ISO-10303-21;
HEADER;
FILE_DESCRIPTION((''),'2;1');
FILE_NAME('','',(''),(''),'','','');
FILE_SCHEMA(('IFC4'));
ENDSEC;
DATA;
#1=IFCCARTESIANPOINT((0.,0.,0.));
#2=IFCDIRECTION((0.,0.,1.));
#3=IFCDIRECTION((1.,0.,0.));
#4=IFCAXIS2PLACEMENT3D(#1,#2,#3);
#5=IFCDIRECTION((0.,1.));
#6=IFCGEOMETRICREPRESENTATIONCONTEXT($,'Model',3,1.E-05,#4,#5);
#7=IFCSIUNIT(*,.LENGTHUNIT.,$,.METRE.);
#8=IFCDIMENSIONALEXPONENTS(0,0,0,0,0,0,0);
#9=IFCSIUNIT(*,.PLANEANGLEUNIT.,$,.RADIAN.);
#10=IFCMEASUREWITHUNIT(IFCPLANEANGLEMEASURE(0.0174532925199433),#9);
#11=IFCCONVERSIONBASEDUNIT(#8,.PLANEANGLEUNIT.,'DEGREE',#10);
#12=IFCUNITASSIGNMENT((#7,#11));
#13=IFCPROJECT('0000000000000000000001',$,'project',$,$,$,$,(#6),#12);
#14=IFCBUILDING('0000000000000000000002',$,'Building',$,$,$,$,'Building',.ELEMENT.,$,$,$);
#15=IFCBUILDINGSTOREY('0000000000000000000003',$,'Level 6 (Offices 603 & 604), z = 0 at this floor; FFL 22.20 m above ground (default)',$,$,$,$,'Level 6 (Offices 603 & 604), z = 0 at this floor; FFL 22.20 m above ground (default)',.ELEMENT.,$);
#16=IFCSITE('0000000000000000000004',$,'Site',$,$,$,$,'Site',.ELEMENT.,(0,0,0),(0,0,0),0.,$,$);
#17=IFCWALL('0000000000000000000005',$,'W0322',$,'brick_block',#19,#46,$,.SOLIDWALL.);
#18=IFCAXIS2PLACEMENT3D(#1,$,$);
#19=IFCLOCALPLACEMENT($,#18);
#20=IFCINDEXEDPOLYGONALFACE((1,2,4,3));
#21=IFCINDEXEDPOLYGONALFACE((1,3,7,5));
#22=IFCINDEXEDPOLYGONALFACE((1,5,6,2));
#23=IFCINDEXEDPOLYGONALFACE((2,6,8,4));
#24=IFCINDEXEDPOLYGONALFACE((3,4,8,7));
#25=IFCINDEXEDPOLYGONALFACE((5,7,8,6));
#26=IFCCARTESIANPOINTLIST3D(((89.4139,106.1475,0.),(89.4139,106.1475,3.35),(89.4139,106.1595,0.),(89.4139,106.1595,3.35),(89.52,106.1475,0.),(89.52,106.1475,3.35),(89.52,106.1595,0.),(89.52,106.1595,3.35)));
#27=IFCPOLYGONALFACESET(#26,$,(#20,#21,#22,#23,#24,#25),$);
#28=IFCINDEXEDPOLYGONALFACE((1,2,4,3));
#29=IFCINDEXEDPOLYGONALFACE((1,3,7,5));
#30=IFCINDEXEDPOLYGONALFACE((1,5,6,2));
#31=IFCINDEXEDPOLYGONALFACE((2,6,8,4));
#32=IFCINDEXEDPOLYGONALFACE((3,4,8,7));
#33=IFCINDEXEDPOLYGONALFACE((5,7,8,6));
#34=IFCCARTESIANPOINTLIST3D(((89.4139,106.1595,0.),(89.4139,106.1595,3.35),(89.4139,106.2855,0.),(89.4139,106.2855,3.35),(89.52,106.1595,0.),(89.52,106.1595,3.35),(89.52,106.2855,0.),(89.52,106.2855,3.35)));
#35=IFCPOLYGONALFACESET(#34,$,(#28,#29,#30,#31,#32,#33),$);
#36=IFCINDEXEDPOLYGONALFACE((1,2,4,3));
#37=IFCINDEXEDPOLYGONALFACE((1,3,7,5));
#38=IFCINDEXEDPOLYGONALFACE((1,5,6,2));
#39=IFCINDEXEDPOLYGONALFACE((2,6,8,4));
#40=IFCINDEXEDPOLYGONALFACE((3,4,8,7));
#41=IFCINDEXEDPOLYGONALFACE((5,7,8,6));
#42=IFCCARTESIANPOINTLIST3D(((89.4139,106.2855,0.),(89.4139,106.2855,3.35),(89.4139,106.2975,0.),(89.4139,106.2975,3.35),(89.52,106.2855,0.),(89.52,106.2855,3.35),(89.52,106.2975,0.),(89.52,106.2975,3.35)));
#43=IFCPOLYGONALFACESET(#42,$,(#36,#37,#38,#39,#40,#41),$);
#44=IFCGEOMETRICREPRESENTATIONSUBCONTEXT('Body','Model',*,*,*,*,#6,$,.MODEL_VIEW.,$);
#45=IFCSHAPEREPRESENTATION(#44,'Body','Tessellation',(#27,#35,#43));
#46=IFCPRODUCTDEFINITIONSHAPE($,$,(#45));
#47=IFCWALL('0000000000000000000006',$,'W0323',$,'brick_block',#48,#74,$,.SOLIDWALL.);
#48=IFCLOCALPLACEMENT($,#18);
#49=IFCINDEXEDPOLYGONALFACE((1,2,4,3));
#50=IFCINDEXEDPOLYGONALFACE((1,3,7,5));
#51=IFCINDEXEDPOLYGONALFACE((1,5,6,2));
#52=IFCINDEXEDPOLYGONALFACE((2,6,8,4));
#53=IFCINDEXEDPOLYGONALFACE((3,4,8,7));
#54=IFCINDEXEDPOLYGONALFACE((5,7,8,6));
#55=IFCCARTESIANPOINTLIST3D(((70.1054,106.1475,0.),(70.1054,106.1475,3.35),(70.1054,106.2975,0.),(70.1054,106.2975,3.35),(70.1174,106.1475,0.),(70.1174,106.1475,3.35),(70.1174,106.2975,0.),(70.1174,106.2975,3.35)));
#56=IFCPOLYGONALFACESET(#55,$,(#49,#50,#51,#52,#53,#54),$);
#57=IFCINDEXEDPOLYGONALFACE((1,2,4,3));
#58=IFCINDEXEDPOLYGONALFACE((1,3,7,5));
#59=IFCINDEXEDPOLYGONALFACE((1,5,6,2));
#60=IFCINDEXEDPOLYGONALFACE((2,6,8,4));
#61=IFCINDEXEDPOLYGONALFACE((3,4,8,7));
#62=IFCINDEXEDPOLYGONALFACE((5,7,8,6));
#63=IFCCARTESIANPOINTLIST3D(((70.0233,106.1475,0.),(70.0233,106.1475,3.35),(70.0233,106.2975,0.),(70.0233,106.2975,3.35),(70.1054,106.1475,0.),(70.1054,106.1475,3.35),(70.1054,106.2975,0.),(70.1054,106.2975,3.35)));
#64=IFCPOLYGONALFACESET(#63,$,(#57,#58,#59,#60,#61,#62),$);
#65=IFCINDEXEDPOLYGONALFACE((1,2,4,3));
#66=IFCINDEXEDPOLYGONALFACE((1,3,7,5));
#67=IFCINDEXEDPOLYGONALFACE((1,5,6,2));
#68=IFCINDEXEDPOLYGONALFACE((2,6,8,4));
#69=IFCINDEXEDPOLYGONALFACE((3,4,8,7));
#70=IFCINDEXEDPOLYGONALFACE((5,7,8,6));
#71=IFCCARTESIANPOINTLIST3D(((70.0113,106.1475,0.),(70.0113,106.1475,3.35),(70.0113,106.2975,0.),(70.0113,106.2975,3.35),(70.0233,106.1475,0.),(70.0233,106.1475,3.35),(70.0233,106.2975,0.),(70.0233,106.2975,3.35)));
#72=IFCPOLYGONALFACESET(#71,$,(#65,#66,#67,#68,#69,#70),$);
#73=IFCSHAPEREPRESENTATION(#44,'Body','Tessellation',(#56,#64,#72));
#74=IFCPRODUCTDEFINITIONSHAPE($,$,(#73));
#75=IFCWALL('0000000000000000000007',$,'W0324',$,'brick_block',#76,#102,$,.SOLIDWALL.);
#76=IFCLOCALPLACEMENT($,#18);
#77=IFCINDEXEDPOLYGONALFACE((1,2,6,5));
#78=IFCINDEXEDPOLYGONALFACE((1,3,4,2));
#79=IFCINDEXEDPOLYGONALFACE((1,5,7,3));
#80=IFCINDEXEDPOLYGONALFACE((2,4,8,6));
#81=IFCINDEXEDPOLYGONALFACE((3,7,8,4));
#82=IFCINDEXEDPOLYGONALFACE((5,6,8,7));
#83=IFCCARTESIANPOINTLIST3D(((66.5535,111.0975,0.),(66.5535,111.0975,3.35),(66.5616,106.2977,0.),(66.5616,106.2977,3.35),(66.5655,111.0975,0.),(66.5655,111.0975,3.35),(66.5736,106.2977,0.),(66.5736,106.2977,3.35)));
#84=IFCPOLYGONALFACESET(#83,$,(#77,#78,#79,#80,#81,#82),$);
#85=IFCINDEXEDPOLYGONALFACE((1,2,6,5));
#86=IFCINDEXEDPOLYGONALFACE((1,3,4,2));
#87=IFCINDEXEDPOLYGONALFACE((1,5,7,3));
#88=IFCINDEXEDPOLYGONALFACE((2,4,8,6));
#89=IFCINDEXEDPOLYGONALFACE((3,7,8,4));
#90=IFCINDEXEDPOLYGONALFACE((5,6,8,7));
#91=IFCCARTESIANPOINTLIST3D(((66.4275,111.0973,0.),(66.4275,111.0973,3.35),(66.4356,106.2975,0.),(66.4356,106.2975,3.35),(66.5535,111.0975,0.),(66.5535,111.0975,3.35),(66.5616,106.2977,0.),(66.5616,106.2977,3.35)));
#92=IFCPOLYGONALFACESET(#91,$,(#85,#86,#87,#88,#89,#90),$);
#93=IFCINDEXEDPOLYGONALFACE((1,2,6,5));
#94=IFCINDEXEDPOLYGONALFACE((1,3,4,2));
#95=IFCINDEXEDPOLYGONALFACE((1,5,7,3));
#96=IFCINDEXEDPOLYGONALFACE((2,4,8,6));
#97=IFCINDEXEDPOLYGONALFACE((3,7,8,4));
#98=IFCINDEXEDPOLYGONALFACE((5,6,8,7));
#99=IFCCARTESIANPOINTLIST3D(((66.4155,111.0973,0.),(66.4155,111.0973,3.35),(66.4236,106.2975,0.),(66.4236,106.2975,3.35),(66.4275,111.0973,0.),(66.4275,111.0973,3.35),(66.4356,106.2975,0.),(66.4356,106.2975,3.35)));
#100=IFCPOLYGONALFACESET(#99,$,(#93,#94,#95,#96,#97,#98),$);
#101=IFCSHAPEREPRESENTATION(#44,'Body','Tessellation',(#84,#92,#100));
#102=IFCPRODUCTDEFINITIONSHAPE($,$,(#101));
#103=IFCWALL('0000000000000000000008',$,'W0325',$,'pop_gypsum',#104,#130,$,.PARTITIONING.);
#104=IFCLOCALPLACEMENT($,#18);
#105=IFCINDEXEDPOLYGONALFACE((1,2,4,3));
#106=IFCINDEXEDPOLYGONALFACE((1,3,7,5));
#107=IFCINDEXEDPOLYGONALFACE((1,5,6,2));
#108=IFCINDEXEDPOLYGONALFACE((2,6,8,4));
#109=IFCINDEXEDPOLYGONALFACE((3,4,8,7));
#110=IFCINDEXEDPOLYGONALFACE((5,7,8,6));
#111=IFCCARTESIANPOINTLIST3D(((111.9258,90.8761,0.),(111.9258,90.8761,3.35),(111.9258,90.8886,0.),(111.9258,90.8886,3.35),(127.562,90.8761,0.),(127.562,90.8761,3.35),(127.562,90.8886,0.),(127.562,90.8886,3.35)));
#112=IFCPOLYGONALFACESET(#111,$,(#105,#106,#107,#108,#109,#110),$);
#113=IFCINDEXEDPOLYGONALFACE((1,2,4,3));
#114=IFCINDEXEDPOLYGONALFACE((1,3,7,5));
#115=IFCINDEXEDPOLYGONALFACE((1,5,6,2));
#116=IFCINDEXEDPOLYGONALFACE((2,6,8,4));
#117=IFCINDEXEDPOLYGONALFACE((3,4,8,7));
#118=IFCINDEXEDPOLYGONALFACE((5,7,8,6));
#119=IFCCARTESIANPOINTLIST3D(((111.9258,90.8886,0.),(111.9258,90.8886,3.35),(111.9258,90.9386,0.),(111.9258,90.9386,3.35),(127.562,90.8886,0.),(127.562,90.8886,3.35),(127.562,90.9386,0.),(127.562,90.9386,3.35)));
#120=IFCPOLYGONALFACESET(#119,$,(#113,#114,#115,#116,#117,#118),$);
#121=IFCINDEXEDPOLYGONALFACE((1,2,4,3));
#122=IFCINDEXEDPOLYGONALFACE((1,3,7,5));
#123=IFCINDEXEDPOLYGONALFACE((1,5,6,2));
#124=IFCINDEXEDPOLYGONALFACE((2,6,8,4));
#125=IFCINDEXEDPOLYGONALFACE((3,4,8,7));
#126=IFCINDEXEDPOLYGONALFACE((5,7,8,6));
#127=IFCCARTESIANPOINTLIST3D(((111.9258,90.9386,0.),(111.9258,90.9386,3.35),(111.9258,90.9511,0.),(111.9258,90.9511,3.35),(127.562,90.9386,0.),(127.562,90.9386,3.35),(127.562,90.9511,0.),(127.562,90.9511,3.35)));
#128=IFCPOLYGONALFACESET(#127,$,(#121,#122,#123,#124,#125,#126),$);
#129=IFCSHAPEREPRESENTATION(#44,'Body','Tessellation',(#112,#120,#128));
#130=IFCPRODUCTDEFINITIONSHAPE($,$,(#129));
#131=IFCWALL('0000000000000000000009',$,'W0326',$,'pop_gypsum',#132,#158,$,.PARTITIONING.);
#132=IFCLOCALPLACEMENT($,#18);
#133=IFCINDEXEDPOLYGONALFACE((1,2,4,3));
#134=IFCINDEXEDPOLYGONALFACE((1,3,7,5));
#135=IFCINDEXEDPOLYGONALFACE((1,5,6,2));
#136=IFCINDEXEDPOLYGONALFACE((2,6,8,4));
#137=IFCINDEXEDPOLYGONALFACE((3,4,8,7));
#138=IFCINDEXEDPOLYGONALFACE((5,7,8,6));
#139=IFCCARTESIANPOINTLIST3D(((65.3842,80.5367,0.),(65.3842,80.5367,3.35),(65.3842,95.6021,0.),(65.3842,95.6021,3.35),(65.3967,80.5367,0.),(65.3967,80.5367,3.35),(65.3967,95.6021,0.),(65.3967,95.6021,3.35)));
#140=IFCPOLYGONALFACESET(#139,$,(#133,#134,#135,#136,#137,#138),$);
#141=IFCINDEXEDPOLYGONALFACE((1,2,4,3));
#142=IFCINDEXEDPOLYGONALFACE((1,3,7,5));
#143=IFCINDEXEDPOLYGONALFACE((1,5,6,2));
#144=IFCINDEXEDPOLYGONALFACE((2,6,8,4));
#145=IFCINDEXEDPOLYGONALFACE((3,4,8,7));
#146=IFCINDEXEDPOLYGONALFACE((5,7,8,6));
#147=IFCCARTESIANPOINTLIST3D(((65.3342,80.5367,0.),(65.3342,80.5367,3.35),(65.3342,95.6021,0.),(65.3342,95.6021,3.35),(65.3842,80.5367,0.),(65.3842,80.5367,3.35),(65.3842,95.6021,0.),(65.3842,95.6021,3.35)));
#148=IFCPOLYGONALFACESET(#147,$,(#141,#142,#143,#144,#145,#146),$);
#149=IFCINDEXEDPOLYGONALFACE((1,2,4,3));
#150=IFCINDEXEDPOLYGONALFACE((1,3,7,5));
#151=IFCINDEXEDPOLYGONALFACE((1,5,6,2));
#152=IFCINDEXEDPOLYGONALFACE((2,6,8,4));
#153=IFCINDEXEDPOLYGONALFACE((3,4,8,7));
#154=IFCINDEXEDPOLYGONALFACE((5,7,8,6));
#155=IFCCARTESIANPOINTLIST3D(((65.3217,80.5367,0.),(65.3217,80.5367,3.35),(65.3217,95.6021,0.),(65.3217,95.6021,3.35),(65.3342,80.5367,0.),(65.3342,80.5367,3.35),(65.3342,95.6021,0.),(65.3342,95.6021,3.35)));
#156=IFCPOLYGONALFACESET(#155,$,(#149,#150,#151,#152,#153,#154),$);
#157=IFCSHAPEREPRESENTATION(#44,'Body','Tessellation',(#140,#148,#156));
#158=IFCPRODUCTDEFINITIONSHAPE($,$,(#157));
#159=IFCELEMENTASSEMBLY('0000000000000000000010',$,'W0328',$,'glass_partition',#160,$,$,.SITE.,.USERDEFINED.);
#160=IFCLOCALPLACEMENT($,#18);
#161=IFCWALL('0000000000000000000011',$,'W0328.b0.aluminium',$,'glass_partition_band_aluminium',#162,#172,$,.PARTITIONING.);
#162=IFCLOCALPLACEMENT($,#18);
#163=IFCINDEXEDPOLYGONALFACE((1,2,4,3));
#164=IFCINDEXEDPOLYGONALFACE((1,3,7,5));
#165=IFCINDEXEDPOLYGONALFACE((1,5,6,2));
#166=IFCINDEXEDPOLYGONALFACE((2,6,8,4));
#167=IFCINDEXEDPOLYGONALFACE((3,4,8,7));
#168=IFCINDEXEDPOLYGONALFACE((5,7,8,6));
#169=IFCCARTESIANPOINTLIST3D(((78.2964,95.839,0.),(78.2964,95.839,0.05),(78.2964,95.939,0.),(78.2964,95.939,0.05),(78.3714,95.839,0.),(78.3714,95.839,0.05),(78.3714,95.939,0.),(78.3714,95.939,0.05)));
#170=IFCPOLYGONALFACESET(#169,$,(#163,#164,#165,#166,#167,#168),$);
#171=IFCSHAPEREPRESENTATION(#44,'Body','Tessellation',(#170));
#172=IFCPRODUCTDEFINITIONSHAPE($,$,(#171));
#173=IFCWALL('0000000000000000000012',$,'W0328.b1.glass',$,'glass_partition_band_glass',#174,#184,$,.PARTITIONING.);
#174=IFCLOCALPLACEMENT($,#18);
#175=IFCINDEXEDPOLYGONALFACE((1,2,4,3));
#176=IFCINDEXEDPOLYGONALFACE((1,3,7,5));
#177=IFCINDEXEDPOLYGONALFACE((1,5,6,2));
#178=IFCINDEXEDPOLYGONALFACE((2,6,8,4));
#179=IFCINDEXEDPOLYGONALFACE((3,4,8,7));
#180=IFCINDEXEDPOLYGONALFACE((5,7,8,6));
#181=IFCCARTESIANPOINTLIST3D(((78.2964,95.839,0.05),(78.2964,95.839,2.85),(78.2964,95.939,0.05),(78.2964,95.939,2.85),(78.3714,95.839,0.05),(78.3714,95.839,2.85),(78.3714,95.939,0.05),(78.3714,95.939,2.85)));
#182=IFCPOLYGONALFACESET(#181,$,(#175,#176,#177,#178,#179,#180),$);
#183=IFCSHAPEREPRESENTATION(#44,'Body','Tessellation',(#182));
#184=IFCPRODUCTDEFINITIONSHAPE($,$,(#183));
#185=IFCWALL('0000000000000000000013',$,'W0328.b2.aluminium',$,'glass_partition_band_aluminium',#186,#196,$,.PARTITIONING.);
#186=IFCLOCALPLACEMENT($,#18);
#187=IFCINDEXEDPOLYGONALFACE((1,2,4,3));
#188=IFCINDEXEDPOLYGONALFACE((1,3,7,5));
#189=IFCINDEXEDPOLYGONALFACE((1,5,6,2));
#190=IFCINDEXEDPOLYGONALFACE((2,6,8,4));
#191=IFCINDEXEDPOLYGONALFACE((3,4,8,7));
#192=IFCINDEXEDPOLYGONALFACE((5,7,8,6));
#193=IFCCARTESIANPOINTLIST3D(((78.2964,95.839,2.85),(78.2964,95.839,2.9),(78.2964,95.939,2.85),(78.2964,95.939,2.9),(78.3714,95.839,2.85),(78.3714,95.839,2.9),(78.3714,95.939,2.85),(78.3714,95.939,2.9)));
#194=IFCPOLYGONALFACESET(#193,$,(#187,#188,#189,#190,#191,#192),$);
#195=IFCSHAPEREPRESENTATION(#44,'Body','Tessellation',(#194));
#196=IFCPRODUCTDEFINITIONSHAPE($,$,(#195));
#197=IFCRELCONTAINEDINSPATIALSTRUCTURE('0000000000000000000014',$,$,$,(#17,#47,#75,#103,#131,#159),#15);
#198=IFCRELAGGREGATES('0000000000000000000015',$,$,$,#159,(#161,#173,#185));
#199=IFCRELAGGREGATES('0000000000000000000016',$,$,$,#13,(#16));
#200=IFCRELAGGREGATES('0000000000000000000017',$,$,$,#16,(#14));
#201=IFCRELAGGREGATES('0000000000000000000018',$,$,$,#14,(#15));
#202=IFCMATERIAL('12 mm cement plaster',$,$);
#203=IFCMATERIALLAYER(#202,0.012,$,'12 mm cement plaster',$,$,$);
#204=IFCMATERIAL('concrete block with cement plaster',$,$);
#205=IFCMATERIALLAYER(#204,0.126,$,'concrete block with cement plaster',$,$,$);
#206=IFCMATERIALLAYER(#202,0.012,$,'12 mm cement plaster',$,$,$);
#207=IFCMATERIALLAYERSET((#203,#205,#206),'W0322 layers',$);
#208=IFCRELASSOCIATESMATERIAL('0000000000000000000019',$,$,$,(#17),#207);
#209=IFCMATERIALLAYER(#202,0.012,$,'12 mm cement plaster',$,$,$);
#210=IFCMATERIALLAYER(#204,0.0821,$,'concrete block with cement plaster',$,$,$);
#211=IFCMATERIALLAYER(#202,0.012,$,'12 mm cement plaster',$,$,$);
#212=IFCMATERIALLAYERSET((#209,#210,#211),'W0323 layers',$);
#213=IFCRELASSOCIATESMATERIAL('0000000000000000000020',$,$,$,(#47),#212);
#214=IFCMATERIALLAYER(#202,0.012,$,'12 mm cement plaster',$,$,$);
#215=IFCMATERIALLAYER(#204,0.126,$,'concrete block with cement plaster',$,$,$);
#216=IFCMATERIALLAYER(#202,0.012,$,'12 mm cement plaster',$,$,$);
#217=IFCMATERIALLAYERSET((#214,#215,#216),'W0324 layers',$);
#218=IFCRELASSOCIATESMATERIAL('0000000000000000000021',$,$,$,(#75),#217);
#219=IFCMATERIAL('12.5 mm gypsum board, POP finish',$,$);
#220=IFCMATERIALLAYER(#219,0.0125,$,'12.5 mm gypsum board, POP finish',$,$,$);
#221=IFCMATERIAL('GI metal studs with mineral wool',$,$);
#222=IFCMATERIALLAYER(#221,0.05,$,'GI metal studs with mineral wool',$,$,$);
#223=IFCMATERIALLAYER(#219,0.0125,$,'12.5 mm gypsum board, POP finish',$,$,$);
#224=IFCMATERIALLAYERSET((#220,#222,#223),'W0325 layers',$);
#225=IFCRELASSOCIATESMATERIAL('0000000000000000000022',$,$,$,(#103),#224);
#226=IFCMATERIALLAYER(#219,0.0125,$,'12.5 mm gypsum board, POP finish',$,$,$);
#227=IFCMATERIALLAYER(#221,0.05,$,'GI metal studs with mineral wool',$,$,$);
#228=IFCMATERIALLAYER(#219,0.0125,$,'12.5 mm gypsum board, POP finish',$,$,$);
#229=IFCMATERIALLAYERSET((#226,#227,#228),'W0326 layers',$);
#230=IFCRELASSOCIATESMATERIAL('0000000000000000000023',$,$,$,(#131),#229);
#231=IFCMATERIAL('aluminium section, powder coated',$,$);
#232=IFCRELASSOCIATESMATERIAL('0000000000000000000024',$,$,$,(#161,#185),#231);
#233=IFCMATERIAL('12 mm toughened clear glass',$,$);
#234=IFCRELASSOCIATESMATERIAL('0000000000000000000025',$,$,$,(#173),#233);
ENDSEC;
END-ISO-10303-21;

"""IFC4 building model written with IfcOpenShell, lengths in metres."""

from ifc_helpers import new_model, entity, si_unit, converted_unit, direction, frame, frame_2d, origin_with_axes, origin_2d_with_axis, place, context, subcontext, project, spatial, rectangle, extrude, material, layer, layer_set, layer_usage, element, aggregate, save


model = new_model("IFC4")

# Units and contexts
model_context = context("Model", 3, precision=1e-05, world=origin_with_axes(), true_north=direction((0.0, 1.0)))
body_context = subcontext(model_context, "Body", "Model", "MODEL_VIEW")
ifc_project = project(units=[si_unit("LENGTHUNIT", "METRE"), converted_unit("PLANEANGLEUNIT", "DEGREE", entity("IfcPlaneAngleMeasure", 0.0174532925199433), si_unit("PLANEANGLEUNIT", "RADIAN"), dimensions=[0, 0, 0, 0, 0, 0, 0])], contexts=[model_context])

# Site, building, storey
site = spatial("IfcSite", under=ifc_project, Name="Site", LongName="Site", CompositionType="ELEMENT", RefLatitude=(0, 0, 0), RefLongitude=(0, 0, 0), RefElevation=0.0)
building = spatial("IfcBuilding", under=site, Name="Building", LongName="Building", CompositionType="ELEMENT")
storey = spatial("IfcBuildingStorey", under=building, Name="Level 6 (Offices 603 & 604), z = 0 at this floor; FFL 22.20 m above ground (default)", LongName="Level 6 (Offices 603 & 604), z = 0 at this floor; FFL 22.20 m above ground (default)", CompositionType="ELEMENT")

# Shared definitions
placement = place(None, origin_with_axes())

# Shared definitions
ifc_material_1 = material(Name="12 mm toughened clear glass")

# Walls
ifc_material_2 = material(Name="12 mm cement plaster")
ifc_material_3 = material(Name="concrete block with cement plaster")
ifc_layer_1 = layer(ifc_material_2, 0.012, Name="12 mm cement plaster")
ifc_layer_2 = layer(ifc_material_3, 0.126, Name="concrete block with cement plaster")
ifc_layer_3 = layer(ifc_material_2, 0.012, Name="12 mm cement plaster")
ifc_layer_set_1 = layer_set([ifc_layer_1, ifc_layer_2, ifc_layer_3], Name="W0322 layers")
ifc_layer_usage_1 = layer_usage(ifc_layer_set_1, "AXIS2", "POSITIVE", -0.075)
element("IfcWall", 1, at=placement, inside=storey, material=ifc_layer_usage_1, Name="W0322", ObjectType="brick_block", PredefinedType="SOLIDWALL", context=body_context, shape_type="SweptSolid", body=[
    extrude(rectangle(XDim=0.1061, YDim=0.012, at=origin_2d_with_axis()), frame((89.4669, 106.1535, 0.0), z_axis=(0.0, 0.0, 1.0), x_axis=(1.0, 0.0, 0.0)), (0.0, 0.0, 1.0), 3.35),
    extrude(rectangle(XDim=0.1061, YDim=0.126, at=frame_2d((0.0, 0.069), x_axis=(1.0, 0.0))), frame((89.4669, 106.1535, 0.0), z_axis=(0.0, 0.0, 1.0), x_axis=(1.0, 0.0, 0.0)), (0.0, 0.0, 1.0), 3.35),
    extrude(rectangle(XDim=0.1061, YDim=0.012, at=frame_2d((0.0, 0.138), x_axis=(1.0, 0.0))), frame((89.4669, 106.1535, 0.0), z_axis=(0.0, 0.0, 1.0), x_axis=(1.0, 0.0, 0.0)), (0.0, 0.0, 1.0), 3.35),
])
ifc_layer_4 = layer(ifc_material_2, 0.012, Name="12 mm cement plaster")
ifc_layer_5 = layer(ifc_material_3, 0.0821, Name="concrete block with cement plaster")
ifc_layer_6 = layer(ifc_material_2, 0.012, Name="12 mm cement plaster")
ifc_layer_set_2 = layer_set([ifc_layer_4, ifc_layer_5, ifc_layer_6], Name="W0323 layers")
ifc_layer_usage_2 = layer_usage(ifc_layer_set_2, "AXIS2", "POSITIVE", -0.053)
element("IfcWall", 2, at=placement, inside=storey, material=ifc_layer_usage_2, Name="W0323", ObjectType="brick_block", PredefinedType="SOLIDWALL", context=body_context, shape_type="SweptSolid", body=[
    extrude(rectangle(XDim=0.15, YDim=0.012, at=frame_2d((0.0, 0.0), x_axis=(0.0, 1.0))), frame((70.1115, 106.2225, 0.0), z_axis=(0.0, 0.0, 1.0), x_axis=(1.0, 0.0, 0.0)), (0.0, 0.0, 1.0), 3.35),
    extrude(rectangle(XDim=0.15, YDim=0.0821, at=frame_2d((-0.0471, 0.0), x_axis=(0.0, 1.0))), frame((70.1115, 106.2225, 0.0), z_axis=(0.0, 0.0, 1.0), x_axis=(1.0, 0.0, 0.0)), (0.0, 0.0, 1.0), 3.35),
    extrude(rectangle(XDim=0.15, YDim=0.012, at=frame_2d((-0.0941, 0.0), x_axis=(0.0, 1.0))), frame((70.1115, 106.2225, 0.0), z_axis=(0.0, 0.0, 1.0), x_axis=(1.0, 0.0, 0.0)), (0.0, 0.0, 1.0), 3.35),
])
ifc_layer_7 = layer(ifc_material_2, 0.012, Name="12 mm cement plaster")
ifc_layer_8 = layer(ifc_material_3, 0.126, Name="concrete block with cement plaster")
ifc_layer_9 = layer(ifc_material_2, 0.012, Name="12 mm cement plaster")
ifc_layer_set_3 = layer_set([ifc_layer_7, ifc_layer_8, ifc_layer_9], Name="W0324 layers")
ifc_layer_usage_3 = layer_usage(ifc_layer_set_3, "AXIS2", "POSITIVE", -0.075)
element("IfcWall", 3, at=placement, inside=storey, material=ifc_layer_usage_3, Name="W0324", ObjectType="brick_block", PredefinedType="SOLIDWALL", context=body_context, shape_type="SweptSolid", body=[
    extrude(rectangle(XDim=4.7998, YDim=0.012, at=frame_2d((0.0, 0.0), x_axis=(0.001688, -0.999999))), frame((66.5635, 108.6976, 0.0), z_axis=(0.0, 0.0, 1.0), x_axis=(1.0, 0.0, 0.0)), (0.0, 0.0, 1.0), 3.35),
    extrude(rectangle(XDim=4.7998, YDim=0.126, at=frame_2d((-0.069, -0.0001), x_axis=(0.001688, -0.999999))), frame((66.5635, 108.6976, 0.0), z_axis=(0.0, 0.0, 1.0), x_axis=(1.0, 0.0, 0.0)), (0.0, 0.0, 1.0), 3.35),
    extrude(rectangle(XDim=4.7998, YDim=0.012, at=frame_2d((-0.138, -0.0002), x_axis=(0.001688, -0.999999))), frame((66.5635, 108.6976, 0.0), z_axis=(0.0, 0.0, 1.0), x_axis=(1.0, 0.0, 0.0)), (0.0, 0.0, 1.0), 3.35),
])
ifc_material_4 = material(Name="12.5 mm gypsum board, POP finish")
ifc_layer_10 = layer(ifc_material_4, 0.0125, Name="12.5 mm gypsum board, POP finish")
ifc_material_5 = material(Name="GI metal studs with mineral wool")
ifc_layer_11 = layer(ifc_material_5, 0.05, Name="GI metal studs with mineral wool")
ifc_layer_12 = layer(ifc_material_4, 0.0125, Name="12.5 mm gypsum board, POP finish")
ifc_layer_set_4 = layer_set([ifc_layer_10, ifc_layer_11, ifc_layer_12], Name="W0325 layers")
ifc_layer_usage_4 = layer_usage(ifc_layer_set_4, "AXIS2", "POSITIVE", -0.0375)
element("IfcWall", 4, at=placement, inside=storey, material=ifc_layer_usage_4, Name="W0325", ObjectType="pop_gypsum", PredefinedType="PARTITIONING", context=body_context, shape_type="SweptSolid", body=[
    extrude(rectangle(XDim=15.6362, YDim=0.0125, at=origin_2d_with_axis()), frame((119.7439, 90.8824, 0.0), z_axis=(0.0, 0.0, 1.0), x_axis=(1.0, 0.0, 0.0)), (0.0, 0.0, 1.0), 3.35),
    extrude(rectangle(XDim=15.6362, YDim=0.05, at=frame_2d((0.0, 0.0312), x_axis=(1.0, 0.0))), frame((119.7439, 90.8824, 0.0), z_axis=(0.0, 0.0, 1.0), x_axis=(1.0, 0.0, 0.0)), (0.0, 0.0, 1.0), 3.35),
    extrude(rectangle(XDim=15.6362, YDim=0.0125, at=frame_2d((0.0, 0.0625), x_axis=(1.0, 0.0))), frame((119.7439, 90.8824, 0.0), z_axis=(0.0, 0.0, 1.0), x_axis=(1.0, 0.0, 0.0)), (0.0, 0.0, 1.0), 3.35),
])
ifc_layer_13 = layer(ifc_material_4, 0.0125, Name="12.5 mm gypsum board, POP finish")
ifc_layer_14 = layer(ifc_material_5, 0.05, Name="GI metal studs with mineral wool")
ifc_layer_15 = layer(ifc_material_4, 0.0125, Name="12.5 mm gypsum board, POP finish")
ifc_layer_set_5 = layer_set([ifc_layer_13, ifc_layer_14, ifc_layer_15], Name="W0326 layers")
ifc_layer_usage_5 = layer_usage(ifc_layer_set_5, "AXIS2", "POSITIVE", -0.0375)
element("IfcWall", 5, at=placement, inside=storey, material=ifc_layer_usage_5, Name="W0326", ObjectType="pop_gypsum", PredefinedType="PARTITIONING", context=body_context, shape_type="SweptSolid", body=[
    extrude(rectangle(XDim=15.0654, YDim=0.0125, at=frame_2d((0.0, 0.0), x_axis=(0.0, 1.0))), frame((65.3905, 88.0694, 0.0), z_axis=(0.0, 0.0, 1.0), x_axis=(1.0, 0.0, 0.0)), (0.0, 0.0, 1.0), 3.35),
    extrude(rectangle(XDim=15.0654, YDim=0.05, at=frame_2d((-0.0312, 0.0), x_axis=(0.0, 1.0))), frame((65.3905, 88.0694, 0.0), z_axis=(0.0, 0.0, 1.0), x_axis=(1.0, 0.0, 0.0)), (0.0, 0.0, 1.0), 3.35),
    extrude(rectangle(XDim=15.0654, YDim=0.0125, at=frame_2d((-0.0625, 0.0), x_axis=(0.0, 1.0))), frame((65.3905, 88.0694, 0.0), z_axis=(0.0, 0.0, 1.0), x_axis=(1.0, 0.0, 0.0)), (0.0, 0.0, 1.0), 3.35),
])

# Element assembly, walls
assembly_1 = element("IfcElementAssembly", 6, inside=storey, Name="W0328", ObjectType="glass_partition", AssemblyPlace="SITE", PredefinedType="USERDEFINED")
ifc_material_6 = material(Name="aluminium section, powder coated")
wall_1 = element("IfcWall", 7, at=placement, material=ifc_material_6, Name="W0328.b0.aluminium", ObjectType="glass_partition_band_aluminium", PredefinedType="PARTITIONING", context=body_context, shape_type="SweptSolid", body=[
    extrude(rectangle(XDim=0.1, YDim=0.075, at=frame_2d((0.0, 0.0), x_axis=(0.0, 1.0))), frame((78.3339, 95.889, 0.0), z_axis=(0.0, 0.0, 1.0), x_axis=(1.0, 0.0, 0.0)), (0.0, 0.0, 1.0), 0.05),
])
wall_2 = element("IfcWall", 8, at=placement, material=ifc_material_1, Name="W0328.b1.glass", ObjectType="glass_partition_band_glass", PredefinedType="PARTITIONING", context=body_context, shape_type="SweptSolid", body=[
    extrude(rectangle(XDim=0.1, YDim=0.075, at=frame_2d((0.0, 0.0), x_axis=(0.0, 1.0))), frame((78.3339, 95.889, 0.05), z_axis=(0.0, 0.0, 1.0), x_axis=(1.0, 0.0, 0.0)), (0.0, 0.0, 1.0), 2.8),
])
wall_3 = element("IfcWall", 9, at=placement, material=ifc_material_6, Name="W0328.b2.aluminium", ObjectType="glass_partition_band_aluminium", PredefinedType="PARTITIONING", context=body_context, shape_type="SweptSolid", body=[
    extrude(rectangle(XDim=0.1, YDim=0.075, at=frame_2d((0.0, 0.0), x_axis=(0.0, 1.0))), frame((78.3339, 95.889, 2.85), z_axis=(0.0, 0.0, 1.0), x_axis=(1.0, 0.0, 0.0)), (0.0, 0.0, 1.0), 0.05),
])
aggregate(assembly_1, [wall_1, wall_2, wall_3])

save(model, "model.ifc")
